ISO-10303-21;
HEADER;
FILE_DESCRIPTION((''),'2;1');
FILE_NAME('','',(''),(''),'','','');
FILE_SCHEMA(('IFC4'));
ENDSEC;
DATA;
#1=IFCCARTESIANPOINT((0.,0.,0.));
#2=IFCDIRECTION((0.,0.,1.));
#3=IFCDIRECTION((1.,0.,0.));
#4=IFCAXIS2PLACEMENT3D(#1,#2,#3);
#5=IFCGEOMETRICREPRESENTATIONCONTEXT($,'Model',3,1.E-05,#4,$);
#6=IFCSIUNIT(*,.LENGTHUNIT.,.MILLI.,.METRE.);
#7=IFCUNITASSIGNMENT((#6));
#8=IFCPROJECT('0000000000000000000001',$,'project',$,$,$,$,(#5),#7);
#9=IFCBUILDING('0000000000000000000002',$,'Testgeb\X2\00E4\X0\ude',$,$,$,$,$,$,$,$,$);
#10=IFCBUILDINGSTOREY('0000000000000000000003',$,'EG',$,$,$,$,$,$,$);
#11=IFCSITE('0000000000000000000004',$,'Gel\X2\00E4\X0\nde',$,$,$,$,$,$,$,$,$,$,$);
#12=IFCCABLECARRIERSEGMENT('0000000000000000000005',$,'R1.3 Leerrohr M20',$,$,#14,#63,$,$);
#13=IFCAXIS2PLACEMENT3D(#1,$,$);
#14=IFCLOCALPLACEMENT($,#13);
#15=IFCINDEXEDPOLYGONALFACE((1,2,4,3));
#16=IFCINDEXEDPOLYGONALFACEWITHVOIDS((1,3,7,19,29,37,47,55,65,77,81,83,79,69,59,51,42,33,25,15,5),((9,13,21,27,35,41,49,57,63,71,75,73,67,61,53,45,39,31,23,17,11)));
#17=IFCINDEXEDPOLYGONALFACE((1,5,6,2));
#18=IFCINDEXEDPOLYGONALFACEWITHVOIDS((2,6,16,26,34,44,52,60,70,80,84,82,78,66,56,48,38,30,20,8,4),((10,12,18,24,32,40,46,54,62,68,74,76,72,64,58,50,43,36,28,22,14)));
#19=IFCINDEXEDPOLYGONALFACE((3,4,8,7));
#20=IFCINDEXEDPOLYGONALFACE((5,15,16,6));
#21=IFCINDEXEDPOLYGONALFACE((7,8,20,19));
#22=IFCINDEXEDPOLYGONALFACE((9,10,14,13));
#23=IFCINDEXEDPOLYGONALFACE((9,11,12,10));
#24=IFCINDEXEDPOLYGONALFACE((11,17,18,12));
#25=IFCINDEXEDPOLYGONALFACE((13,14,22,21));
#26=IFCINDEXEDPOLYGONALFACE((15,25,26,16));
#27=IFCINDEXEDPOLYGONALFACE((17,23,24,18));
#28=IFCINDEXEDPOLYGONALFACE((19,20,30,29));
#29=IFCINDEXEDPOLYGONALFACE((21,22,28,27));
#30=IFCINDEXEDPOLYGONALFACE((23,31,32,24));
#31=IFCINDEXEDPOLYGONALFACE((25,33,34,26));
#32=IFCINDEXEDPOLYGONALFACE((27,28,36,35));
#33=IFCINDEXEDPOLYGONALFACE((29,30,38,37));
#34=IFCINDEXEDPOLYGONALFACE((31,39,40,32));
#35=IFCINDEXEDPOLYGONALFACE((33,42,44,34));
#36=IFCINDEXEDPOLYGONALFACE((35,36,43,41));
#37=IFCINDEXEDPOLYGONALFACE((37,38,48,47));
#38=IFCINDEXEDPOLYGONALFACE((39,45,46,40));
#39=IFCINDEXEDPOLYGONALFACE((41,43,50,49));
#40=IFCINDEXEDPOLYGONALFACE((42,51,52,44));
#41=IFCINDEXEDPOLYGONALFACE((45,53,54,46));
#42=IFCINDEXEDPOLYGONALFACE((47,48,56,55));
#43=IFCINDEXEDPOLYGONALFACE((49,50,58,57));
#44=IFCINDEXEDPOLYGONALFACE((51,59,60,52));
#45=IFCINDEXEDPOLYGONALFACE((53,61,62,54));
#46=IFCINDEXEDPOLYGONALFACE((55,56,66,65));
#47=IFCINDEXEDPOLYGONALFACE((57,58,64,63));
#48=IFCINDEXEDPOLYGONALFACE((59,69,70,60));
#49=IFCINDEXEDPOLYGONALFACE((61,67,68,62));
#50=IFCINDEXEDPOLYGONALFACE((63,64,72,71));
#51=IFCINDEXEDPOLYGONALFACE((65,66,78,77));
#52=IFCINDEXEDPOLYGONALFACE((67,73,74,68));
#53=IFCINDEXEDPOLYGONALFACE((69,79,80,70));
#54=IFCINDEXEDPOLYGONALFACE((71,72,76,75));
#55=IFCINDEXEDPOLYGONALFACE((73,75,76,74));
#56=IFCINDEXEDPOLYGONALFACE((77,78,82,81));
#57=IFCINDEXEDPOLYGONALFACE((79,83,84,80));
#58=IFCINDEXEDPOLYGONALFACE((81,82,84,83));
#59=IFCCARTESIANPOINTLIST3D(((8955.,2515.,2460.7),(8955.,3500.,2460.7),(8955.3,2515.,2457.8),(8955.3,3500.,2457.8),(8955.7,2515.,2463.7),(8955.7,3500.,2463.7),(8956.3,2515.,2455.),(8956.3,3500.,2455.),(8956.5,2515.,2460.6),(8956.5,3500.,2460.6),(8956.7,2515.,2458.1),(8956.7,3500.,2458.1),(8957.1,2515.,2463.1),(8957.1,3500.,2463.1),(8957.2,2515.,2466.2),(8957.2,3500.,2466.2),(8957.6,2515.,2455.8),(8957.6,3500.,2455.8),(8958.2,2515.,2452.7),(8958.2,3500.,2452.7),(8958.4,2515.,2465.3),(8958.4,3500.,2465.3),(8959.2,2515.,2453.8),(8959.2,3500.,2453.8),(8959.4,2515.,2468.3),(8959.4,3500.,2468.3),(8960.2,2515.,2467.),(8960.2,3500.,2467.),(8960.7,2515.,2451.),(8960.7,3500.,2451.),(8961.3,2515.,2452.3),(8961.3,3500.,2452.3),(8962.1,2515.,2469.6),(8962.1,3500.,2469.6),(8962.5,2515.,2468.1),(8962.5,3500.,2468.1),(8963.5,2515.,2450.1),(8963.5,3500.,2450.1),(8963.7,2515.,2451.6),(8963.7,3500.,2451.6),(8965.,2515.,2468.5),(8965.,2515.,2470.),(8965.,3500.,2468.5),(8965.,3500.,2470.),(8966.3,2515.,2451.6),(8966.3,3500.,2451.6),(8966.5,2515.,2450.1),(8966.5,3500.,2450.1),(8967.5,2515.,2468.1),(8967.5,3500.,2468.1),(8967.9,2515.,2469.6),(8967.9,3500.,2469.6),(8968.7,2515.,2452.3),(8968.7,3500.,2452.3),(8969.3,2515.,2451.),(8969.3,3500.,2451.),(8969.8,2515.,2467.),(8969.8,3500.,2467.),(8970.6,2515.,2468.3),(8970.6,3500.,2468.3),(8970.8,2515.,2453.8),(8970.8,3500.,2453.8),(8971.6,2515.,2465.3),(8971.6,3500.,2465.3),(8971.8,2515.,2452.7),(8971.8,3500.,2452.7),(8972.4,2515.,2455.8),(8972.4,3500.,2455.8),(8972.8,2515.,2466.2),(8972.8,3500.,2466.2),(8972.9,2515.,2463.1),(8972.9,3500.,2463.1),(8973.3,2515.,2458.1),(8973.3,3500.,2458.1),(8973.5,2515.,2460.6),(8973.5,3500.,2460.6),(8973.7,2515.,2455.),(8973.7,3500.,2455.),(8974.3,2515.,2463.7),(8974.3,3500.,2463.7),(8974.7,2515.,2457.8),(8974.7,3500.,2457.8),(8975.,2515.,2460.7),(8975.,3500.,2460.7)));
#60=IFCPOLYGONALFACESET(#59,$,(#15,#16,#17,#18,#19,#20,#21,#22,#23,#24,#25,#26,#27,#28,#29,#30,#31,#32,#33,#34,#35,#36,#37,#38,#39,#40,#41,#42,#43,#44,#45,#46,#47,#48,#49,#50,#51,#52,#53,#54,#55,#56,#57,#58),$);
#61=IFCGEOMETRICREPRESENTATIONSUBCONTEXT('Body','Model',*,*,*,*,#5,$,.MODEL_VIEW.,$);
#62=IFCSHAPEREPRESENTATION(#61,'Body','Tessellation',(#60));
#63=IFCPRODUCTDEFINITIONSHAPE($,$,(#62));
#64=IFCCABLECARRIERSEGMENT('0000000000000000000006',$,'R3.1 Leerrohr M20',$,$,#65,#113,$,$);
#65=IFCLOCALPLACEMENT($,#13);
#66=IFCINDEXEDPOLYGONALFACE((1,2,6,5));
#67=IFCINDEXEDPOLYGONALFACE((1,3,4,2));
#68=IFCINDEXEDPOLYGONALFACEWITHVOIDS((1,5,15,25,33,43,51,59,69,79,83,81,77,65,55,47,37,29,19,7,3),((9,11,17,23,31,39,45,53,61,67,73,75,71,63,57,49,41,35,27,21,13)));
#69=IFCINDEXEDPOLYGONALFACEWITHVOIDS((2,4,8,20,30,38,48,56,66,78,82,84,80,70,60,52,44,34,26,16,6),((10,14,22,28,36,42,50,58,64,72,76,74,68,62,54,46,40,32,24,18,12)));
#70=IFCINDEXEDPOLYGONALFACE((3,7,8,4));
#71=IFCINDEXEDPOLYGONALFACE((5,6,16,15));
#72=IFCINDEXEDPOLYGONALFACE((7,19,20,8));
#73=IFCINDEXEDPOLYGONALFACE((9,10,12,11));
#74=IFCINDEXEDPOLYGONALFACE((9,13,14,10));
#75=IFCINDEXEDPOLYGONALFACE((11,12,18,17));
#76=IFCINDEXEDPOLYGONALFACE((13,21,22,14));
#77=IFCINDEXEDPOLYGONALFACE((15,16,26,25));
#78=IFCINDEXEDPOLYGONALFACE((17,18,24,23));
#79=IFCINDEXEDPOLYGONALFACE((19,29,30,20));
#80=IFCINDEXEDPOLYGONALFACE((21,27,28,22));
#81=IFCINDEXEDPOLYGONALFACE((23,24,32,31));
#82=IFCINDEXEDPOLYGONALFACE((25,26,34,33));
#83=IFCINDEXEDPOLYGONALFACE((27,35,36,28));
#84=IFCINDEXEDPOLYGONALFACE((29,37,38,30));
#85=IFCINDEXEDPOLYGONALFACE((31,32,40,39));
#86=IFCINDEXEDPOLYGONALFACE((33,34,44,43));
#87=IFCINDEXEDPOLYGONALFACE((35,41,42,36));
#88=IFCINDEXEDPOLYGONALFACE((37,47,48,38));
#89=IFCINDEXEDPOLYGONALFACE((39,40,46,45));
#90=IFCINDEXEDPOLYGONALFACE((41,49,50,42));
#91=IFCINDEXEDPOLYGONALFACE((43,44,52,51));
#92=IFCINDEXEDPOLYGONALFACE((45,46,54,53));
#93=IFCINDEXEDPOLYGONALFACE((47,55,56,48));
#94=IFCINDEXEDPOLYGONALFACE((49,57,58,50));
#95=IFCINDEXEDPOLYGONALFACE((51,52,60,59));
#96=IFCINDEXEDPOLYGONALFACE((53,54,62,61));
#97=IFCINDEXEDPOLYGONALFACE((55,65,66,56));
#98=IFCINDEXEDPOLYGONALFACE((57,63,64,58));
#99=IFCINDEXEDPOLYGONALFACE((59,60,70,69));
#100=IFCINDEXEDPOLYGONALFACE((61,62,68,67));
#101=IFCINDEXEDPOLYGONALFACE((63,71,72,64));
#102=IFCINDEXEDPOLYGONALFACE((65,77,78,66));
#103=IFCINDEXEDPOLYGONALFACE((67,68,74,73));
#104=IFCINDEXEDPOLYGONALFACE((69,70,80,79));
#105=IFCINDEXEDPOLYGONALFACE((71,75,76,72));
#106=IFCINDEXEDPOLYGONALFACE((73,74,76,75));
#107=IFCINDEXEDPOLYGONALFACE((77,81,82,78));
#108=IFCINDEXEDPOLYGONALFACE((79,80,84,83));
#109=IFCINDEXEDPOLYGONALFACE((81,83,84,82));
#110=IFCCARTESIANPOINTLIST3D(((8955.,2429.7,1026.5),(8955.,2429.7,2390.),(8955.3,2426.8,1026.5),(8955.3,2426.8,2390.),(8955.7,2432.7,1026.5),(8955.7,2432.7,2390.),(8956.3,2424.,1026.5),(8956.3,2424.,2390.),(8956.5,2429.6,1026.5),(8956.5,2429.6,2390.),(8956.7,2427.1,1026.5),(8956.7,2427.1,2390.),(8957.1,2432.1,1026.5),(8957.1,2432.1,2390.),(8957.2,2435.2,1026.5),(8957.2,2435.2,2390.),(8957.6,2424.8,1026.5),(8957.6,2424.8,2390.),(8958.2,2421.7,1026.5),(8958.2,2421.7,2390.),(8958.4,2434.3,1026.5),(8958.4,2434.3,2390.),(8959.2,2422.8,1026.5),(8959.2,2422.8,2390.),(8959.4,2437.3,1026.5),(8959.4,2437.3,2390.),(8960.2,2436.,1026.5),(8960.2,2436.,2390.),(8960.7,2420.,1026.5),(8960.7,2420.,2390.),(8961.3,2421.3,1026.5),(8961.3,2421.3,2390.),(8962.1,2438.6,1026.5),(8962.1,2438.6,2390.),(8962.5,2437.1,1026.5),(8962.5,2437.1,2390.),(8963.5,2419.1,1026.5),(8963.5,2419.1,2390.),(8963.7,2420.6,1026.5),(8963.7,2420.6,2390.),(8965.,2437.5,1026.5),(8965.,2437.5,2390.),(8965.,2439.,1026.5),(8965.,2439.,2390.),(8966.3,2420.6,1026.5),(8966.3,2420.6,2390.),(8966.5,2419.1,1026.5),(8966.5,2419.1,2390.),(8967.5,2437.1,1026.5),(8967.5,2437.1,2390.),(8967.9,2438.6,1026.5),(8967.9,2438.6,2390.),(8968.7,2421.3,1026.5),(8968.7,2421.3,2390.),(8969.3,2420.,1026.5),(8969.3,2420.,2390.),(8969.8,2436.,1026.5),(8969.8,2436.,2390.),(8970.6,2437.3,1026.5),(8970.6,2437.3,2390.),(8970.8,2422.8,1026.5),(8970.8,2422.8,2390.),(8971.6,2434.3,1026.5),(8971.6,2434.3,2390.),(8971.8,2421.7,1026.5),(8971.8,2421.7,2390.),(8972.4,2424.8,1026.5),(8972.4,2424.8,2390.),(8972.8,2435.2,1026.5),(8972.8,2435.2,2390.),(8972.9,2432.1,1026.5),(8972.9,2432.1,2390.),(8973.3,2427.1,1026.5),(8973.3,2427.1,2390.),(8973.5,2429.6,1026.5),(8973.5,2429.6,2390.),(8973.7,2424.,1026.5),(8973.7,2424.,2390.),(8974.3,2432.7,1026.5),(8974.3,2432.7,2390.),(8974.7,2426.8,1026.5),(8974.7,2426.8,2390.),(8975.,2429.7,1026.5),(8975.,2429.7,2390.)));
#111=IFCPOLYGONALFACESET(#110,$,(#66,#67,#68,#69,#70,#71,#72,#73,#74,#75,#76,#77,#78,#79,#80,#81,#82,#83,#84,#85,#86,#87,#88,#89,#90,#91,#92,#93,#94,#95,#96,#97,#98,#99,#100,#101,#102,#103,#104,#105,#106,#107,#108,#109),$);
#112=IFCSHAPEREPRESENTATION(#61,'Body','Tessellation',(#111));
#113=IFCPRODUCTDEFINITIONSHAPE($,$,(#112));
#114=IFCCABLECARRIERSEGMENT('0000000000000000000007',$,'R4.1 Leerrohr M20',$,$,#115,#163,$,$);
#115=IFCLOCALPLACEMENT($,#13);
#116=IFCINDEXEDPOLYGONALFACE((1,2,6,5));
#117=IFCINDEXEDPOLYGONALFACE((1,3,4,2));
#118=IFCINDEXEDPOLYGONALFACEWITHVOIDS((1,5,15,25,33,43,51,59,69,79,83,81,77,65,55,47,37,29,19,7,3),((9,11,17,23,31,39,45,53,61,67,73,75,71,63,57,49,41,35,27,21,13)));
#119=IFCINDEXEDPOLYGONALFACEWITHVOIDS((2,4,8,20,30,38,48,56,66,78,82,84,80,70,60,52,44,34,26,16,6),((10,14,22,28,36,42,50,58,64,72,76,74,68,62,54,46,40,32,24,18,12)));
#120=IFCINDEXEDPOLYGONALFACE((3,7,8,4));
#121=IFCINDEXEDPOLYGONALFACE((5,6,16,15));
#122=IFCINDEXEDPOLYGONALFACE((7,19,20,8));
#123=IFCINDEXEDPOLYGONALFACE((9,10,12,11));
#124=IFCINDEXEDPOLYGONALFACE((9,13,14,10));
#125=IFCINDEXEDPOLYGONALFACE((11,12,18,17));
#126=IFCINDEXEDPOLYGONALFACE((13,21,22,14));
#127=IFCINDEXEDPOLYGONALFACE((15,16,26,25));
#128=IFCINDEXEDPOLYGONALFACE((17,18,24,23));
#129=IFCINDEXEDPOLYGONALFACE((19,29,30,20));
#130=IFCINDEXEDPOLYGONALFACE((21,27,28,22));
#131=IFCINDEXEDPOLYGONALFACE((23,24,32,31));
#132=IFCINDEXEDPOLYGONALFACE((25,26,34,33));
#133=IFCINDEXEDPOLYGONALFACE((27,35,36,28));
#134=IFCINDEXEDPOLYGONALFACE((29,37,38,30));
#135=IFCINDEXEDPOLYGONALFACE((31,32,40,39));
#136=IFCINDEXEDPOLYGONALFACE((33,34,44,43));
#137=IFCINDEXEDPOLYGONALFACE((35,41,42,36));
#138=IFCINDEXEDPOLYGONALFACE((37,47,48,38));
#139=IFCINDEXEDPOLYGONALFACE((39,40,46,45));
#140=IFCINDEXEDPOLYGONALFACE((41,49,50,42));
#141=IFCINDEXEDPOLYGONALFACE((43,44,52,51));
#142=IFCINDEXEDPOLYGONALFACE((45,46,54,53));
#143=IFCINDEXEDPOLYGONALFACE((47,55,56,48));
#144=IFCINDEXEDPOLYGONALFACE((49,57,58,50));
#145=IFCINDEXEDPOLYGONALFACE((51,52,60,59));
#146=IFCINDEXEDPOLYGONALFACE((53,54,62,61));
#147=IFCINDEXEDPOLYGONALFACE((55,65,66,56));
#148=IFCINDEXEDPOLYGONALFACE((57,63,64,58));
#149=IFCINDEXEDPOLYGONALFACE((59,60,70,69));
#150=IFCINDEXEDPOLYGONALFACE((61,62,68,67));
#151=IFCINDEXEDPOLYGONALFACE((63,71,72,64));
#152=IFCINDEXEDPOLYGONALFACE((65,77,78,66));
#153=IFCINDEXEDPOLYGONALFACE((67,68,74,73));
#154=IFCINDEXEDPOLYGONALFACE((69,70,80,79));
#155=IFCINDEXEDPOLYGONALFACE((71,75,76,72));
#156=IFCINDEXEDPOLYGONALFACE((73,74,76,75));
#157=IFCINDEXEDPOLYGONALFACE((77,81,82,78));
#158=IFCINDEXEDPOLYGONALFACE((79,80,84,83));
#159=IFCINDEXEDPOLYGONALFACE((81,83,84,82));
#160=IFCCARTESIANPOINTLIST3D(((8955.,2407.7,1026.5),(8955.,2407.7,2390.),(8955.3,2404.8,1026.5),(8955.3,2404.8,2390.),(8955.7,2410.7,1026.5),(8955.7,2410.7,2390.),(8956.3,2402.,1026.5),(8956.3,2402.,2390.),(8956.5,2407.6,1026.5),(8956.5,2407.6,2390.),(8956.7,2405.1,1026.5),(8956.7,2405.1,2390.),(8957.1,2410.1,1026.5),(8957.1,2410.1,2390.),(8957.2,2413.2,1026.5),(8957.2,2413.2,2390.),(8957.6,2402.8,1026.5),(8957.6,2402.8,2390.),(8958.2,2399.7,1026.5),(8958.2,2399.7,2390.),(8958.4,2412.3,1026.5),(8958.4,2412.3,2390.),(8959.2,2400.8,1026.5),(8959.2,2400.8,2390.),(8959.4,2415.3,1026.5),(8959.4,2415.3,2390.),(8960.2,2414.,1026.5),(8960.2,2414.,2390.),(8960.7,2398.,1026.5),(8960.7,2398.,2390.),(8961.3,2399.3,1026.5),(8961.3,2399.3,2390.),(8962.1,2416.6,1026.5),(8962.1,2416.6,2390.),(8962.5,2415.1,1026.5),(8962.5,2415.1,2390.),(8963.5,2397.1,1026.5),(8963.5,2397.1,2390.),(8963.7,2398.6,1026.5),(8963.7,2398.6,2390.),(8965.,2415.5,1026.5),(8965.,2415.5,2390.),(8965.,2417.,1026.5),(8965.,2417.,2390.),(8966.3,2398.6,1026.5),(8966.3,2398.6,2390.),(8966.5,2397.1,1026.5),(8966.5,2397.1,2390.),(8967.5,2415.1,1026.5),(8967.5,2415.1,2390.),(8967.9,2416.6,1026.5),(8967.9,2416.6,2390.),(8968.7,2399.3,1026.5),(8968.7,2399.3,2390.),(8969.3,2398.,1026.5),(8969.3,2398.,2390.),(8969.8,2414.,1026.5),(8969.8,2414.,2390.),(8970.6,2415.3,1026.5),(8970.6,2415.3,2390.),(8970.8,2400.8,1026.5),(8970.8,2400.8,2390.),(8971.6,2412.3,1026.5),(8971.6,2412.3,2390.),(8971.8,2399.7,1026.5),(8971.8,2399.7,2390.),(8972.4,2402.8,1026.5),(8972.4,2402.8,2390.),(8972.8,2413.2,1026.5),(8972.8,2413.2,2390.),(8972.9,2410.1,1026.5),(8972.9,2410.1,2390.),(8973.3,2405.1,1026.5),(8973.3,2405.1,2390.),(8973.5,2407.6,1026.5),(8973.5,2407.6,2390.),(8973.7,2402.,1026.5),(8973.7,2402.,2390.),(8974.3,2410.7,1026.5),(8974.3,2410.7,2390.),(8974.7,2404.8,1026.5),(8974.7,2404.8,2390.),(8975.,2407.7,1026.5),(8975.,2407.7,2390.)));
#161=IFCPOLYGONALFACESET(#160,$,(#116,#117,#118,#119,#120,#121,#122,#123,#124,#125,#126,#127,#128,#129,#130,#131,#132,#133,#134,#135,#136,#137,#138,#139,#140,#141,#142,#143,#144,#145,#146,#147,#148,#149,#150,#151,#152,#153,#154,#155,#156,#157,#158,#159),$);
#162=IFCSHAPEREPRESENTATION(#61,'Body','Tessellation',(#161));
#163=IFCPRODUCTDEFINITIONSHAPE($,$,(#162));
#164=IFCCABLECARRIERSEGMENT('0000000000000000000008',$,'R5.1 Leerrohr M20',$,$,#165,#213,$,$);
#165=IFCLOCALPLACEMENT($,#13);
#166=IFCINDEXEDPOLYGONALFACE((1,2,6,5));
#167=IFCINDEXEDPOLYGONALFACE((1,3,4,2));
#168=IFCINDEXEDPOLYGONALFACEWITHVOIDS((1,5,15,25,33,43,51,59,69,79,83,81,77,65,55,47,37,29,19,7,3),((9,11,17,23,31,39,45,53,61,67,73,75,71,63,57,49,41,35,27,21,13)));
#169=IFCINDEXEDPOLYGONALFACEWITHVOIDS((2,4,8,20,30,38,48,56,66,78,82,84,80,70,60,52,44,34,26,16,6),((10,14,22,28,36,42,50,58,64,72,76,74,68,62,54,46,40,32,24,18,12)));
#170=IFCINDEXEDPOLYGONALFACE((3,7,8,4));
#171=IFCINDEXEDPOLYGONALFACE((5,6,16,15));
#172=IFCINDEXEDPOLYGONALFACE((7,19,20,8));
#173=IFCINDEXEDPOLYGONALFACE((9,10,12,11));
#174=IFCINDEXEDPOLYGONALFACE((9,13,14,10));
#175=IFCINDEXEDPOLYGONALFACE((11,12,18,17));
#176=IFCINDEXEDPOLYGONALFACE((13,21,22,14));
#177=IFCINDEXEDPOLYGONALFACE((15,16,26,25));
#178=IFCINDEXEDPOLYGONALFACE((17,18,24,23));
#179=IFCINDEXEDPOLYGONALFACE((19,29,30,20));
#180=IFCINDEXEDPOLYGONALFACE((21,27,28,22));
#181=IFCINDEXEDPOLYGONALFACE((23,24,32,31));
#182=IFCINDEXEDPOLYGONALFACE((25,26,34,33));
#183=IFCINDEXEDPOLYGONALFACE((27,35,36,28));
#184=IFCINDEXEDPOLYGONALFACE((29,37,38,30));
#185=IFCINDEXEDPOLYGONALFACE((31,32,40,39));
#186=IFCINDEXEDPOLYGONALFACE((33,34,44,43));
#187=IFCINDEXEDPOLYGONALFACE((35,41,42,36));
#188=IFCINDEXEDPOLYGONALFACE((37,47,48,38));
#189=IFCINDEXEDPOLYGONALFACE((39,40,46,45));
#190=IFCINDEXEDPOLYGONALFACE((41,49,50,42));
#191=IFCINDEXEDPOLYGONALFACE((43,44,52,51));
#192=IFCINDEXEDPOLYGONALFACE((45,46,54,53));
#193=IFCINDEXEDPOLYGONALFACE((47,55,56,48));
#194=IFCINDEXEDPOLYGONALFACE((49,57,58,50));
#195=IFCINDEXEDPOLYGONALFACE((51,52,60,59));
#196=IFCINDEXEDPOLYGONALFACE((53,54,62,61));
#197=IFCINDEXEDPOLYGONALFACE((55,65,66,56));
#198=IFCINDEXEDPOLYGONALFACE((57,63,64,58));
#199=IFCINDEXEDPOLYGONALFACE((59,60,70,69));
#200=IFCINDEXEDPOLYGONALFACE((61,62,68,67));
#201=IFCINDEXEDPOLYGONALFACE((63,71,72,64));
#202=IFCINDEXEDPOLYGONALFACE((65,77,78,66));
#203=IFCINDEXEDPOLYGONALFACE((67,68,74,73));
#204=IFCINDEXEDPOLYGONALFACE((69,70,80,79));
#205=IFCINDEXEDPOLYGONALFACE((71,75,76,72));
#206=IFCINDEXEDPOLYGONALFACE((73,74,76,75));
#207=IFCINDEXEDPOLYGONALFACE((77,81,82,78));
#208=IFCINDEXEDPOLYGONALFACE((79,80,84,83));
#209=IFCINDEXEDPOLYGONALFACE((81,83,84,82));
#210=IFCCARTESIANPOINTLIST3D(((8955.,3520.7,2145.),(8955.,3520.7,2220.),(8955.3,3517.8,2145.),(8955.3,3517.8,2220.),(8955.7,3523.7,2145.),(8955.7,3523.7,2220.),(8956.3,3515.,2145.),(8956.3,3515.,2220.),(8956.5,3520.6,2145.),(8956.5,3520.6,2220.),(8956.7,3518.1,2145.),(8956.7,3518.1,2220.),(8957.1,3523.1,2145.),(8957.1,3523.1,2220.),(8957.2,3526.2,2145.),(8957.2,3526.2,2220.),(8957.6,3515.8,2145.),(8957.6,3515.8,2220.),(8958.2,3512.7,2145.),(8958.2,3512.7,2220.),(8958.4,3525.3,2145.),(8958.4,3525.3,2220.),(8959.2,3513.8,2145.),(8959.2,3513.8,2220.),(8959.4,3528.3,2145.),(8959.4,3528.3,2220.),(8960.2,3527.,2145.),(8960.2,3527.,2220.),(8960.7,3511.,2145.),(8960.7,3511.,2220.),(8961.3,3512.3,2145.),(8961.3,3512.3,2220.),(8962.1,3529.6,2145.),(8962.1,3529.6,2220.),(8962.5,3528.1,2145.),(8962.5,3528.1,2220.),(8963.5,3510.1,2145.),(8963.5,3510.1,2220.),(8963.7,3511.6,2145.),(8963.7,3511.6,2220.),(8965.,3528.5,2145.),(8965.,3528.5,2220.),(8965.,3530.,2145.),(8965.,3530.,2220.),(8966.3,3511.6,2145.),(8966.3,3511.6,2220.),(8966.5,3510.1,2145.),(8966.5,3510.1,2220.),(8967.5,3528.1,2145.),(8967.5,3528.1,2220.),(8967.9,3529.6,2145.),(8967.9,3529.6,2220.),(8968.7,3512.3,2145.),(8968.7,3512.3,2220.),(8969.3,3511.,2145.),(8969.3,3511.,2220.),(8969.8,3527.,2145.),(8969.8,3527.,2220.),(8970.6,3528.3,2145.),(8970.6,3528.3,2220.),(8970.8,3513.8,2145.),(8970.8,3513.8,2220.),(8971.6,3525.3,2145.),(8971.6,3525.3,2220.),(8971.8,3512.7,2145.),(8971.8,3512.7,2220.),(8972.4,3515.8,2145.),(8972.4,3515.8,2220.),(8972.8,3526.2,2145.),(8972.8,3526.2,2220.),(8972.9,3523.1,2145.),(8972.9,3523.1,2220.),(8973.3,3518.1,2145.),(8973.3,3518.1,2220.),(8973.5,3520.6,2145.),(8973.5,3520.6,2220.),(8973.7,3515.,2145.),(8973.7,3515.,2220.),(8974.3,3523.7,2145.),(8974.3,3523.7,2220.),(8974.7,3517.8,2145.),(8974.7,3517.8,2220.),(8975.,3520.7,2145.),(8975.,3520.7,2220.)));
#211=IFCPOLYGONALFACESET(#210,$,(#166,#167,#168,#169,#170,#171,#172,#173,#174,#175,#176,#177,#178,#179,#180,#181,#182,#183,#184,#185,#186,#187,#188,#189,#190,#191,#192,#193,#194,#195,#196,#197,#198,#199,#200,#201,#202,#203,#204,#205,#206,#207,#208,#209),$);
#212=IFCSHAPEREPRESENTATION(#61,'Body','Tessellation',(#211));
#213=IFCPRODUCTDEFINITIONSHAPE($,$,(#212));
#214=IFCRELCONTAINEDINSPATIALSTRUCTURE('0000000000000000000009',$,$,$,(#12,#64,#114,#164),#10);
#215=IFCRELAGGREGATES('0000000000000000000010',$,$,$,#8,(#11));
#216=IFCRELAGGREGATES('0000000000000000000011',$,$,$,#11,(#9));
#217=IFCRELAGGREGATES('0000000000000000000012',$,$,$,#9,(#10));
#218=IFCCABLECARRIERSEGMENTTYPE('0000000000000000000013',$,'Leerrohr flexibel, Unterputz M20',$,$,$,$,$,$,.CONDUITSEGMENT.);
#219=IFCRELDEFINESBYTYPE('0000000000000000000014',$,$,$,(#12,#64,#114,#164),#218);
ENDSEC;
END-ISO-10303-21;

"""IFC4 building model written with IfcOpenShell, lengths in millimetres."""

from ifc_helpers import new_model, si_unit, frame, origin_with_axes, place, context, subcontext, project, spatial, hollow_circle, extrude, type_object, element, save


model = new_model("IFC4")

# Units and contexts
model_context = context("Model", 3, precision=1e-05, world=origin_with_axes())
body_context = subcontext(model_context, "Body", "Model", "MODEL_VIEW")
ifc_project = project(units=[si_unit("LENGTHUNIT", "METRE", prefix="MILLI")], contexts=[model_context])

# Site, building, storey
site = spatial("IfcSite", under=ifc_project, Name="Gelände")
building = spatial("IfcBuilding", under=site, Name="Testgebäude")
storey = spatial("IfcBuildingStorey", under=building, Name="EG")

# Cable carrier segments
cable_carrier_segment_type_1 = type_object("IfcCableCarrierSegmentType", Name="Leerrohr flexibel, Unterputz M20", PredefinedType="CONDUITSEGMENT")
cable_carrier_segment_1_placement = place(None, frame((8965.0, 3500.0, 2460.0), z_axis=(0.0, -1.0, 0.0), x_axis=(0.0, 0.0, 1.0)))
element("IfcCableCarrierSegment", 1, at=cable_carrier_segment_1_placement, inside=storey, type_object=cable_carrier_segment_type_1, Name="R1.3 Leerrohr M20", context=body_context, shape_type="SweptSolid", body=[
    extrude(hollow_circle(Radius=10.0, WallThickness=1.5), None, (0.0, 0.0, 1.0), 985.0),
])
for number, where, z_axis, x_axis, name in (
    (2, (8965.0, 2429.0, 1026.5), (0.0, 0.0, 1.0), (0.0, 1.0, 0.0), "R3.1 Leerrohr M20"),
    (3, (8965.0, 2407.0, 1026.5), (0.0, 0.0, 1.0), (0.0, 1.0, 0.0), "R4.1 Leerrohr M20"),
):
    element("IfcCableCarrierSegment", number, at=place(None, frame(where, z_axis=z_axis, x_axis=x_axis)), inside=storey, type_object=cable_carrier_segment_type_1, Name=name, context=body_context, shape_type="SweptSolid", body=[
        extrude(hollow_circle(Radius=10.0, WallThickness=1.5), None, (0.0, 0.0, 1.0), 1363.5),
    ])
cable_carrier_segment_2_placement = place(None, frame((8965.0, 3520.0, 2145.0), z_axis=(0.0, 0.0, 1.0), x_axis=(0.0, 1.0, 0.0)))
element("IfcCableCarrierSegment", 4, at=cable_carrier_segment_2_placement, inside=storey, type_object=cable_carrier_segment_type_1, Name="R5.1 Leerrohr M20", context=body_context, shape_type="SweptSolid", body=[
    extrude(hollow_circle(Radius=10.0, WallThickness=1.5), None, (0.0, 0.0, 1.0), 75.0),
])

save(model, "model.ifc")
